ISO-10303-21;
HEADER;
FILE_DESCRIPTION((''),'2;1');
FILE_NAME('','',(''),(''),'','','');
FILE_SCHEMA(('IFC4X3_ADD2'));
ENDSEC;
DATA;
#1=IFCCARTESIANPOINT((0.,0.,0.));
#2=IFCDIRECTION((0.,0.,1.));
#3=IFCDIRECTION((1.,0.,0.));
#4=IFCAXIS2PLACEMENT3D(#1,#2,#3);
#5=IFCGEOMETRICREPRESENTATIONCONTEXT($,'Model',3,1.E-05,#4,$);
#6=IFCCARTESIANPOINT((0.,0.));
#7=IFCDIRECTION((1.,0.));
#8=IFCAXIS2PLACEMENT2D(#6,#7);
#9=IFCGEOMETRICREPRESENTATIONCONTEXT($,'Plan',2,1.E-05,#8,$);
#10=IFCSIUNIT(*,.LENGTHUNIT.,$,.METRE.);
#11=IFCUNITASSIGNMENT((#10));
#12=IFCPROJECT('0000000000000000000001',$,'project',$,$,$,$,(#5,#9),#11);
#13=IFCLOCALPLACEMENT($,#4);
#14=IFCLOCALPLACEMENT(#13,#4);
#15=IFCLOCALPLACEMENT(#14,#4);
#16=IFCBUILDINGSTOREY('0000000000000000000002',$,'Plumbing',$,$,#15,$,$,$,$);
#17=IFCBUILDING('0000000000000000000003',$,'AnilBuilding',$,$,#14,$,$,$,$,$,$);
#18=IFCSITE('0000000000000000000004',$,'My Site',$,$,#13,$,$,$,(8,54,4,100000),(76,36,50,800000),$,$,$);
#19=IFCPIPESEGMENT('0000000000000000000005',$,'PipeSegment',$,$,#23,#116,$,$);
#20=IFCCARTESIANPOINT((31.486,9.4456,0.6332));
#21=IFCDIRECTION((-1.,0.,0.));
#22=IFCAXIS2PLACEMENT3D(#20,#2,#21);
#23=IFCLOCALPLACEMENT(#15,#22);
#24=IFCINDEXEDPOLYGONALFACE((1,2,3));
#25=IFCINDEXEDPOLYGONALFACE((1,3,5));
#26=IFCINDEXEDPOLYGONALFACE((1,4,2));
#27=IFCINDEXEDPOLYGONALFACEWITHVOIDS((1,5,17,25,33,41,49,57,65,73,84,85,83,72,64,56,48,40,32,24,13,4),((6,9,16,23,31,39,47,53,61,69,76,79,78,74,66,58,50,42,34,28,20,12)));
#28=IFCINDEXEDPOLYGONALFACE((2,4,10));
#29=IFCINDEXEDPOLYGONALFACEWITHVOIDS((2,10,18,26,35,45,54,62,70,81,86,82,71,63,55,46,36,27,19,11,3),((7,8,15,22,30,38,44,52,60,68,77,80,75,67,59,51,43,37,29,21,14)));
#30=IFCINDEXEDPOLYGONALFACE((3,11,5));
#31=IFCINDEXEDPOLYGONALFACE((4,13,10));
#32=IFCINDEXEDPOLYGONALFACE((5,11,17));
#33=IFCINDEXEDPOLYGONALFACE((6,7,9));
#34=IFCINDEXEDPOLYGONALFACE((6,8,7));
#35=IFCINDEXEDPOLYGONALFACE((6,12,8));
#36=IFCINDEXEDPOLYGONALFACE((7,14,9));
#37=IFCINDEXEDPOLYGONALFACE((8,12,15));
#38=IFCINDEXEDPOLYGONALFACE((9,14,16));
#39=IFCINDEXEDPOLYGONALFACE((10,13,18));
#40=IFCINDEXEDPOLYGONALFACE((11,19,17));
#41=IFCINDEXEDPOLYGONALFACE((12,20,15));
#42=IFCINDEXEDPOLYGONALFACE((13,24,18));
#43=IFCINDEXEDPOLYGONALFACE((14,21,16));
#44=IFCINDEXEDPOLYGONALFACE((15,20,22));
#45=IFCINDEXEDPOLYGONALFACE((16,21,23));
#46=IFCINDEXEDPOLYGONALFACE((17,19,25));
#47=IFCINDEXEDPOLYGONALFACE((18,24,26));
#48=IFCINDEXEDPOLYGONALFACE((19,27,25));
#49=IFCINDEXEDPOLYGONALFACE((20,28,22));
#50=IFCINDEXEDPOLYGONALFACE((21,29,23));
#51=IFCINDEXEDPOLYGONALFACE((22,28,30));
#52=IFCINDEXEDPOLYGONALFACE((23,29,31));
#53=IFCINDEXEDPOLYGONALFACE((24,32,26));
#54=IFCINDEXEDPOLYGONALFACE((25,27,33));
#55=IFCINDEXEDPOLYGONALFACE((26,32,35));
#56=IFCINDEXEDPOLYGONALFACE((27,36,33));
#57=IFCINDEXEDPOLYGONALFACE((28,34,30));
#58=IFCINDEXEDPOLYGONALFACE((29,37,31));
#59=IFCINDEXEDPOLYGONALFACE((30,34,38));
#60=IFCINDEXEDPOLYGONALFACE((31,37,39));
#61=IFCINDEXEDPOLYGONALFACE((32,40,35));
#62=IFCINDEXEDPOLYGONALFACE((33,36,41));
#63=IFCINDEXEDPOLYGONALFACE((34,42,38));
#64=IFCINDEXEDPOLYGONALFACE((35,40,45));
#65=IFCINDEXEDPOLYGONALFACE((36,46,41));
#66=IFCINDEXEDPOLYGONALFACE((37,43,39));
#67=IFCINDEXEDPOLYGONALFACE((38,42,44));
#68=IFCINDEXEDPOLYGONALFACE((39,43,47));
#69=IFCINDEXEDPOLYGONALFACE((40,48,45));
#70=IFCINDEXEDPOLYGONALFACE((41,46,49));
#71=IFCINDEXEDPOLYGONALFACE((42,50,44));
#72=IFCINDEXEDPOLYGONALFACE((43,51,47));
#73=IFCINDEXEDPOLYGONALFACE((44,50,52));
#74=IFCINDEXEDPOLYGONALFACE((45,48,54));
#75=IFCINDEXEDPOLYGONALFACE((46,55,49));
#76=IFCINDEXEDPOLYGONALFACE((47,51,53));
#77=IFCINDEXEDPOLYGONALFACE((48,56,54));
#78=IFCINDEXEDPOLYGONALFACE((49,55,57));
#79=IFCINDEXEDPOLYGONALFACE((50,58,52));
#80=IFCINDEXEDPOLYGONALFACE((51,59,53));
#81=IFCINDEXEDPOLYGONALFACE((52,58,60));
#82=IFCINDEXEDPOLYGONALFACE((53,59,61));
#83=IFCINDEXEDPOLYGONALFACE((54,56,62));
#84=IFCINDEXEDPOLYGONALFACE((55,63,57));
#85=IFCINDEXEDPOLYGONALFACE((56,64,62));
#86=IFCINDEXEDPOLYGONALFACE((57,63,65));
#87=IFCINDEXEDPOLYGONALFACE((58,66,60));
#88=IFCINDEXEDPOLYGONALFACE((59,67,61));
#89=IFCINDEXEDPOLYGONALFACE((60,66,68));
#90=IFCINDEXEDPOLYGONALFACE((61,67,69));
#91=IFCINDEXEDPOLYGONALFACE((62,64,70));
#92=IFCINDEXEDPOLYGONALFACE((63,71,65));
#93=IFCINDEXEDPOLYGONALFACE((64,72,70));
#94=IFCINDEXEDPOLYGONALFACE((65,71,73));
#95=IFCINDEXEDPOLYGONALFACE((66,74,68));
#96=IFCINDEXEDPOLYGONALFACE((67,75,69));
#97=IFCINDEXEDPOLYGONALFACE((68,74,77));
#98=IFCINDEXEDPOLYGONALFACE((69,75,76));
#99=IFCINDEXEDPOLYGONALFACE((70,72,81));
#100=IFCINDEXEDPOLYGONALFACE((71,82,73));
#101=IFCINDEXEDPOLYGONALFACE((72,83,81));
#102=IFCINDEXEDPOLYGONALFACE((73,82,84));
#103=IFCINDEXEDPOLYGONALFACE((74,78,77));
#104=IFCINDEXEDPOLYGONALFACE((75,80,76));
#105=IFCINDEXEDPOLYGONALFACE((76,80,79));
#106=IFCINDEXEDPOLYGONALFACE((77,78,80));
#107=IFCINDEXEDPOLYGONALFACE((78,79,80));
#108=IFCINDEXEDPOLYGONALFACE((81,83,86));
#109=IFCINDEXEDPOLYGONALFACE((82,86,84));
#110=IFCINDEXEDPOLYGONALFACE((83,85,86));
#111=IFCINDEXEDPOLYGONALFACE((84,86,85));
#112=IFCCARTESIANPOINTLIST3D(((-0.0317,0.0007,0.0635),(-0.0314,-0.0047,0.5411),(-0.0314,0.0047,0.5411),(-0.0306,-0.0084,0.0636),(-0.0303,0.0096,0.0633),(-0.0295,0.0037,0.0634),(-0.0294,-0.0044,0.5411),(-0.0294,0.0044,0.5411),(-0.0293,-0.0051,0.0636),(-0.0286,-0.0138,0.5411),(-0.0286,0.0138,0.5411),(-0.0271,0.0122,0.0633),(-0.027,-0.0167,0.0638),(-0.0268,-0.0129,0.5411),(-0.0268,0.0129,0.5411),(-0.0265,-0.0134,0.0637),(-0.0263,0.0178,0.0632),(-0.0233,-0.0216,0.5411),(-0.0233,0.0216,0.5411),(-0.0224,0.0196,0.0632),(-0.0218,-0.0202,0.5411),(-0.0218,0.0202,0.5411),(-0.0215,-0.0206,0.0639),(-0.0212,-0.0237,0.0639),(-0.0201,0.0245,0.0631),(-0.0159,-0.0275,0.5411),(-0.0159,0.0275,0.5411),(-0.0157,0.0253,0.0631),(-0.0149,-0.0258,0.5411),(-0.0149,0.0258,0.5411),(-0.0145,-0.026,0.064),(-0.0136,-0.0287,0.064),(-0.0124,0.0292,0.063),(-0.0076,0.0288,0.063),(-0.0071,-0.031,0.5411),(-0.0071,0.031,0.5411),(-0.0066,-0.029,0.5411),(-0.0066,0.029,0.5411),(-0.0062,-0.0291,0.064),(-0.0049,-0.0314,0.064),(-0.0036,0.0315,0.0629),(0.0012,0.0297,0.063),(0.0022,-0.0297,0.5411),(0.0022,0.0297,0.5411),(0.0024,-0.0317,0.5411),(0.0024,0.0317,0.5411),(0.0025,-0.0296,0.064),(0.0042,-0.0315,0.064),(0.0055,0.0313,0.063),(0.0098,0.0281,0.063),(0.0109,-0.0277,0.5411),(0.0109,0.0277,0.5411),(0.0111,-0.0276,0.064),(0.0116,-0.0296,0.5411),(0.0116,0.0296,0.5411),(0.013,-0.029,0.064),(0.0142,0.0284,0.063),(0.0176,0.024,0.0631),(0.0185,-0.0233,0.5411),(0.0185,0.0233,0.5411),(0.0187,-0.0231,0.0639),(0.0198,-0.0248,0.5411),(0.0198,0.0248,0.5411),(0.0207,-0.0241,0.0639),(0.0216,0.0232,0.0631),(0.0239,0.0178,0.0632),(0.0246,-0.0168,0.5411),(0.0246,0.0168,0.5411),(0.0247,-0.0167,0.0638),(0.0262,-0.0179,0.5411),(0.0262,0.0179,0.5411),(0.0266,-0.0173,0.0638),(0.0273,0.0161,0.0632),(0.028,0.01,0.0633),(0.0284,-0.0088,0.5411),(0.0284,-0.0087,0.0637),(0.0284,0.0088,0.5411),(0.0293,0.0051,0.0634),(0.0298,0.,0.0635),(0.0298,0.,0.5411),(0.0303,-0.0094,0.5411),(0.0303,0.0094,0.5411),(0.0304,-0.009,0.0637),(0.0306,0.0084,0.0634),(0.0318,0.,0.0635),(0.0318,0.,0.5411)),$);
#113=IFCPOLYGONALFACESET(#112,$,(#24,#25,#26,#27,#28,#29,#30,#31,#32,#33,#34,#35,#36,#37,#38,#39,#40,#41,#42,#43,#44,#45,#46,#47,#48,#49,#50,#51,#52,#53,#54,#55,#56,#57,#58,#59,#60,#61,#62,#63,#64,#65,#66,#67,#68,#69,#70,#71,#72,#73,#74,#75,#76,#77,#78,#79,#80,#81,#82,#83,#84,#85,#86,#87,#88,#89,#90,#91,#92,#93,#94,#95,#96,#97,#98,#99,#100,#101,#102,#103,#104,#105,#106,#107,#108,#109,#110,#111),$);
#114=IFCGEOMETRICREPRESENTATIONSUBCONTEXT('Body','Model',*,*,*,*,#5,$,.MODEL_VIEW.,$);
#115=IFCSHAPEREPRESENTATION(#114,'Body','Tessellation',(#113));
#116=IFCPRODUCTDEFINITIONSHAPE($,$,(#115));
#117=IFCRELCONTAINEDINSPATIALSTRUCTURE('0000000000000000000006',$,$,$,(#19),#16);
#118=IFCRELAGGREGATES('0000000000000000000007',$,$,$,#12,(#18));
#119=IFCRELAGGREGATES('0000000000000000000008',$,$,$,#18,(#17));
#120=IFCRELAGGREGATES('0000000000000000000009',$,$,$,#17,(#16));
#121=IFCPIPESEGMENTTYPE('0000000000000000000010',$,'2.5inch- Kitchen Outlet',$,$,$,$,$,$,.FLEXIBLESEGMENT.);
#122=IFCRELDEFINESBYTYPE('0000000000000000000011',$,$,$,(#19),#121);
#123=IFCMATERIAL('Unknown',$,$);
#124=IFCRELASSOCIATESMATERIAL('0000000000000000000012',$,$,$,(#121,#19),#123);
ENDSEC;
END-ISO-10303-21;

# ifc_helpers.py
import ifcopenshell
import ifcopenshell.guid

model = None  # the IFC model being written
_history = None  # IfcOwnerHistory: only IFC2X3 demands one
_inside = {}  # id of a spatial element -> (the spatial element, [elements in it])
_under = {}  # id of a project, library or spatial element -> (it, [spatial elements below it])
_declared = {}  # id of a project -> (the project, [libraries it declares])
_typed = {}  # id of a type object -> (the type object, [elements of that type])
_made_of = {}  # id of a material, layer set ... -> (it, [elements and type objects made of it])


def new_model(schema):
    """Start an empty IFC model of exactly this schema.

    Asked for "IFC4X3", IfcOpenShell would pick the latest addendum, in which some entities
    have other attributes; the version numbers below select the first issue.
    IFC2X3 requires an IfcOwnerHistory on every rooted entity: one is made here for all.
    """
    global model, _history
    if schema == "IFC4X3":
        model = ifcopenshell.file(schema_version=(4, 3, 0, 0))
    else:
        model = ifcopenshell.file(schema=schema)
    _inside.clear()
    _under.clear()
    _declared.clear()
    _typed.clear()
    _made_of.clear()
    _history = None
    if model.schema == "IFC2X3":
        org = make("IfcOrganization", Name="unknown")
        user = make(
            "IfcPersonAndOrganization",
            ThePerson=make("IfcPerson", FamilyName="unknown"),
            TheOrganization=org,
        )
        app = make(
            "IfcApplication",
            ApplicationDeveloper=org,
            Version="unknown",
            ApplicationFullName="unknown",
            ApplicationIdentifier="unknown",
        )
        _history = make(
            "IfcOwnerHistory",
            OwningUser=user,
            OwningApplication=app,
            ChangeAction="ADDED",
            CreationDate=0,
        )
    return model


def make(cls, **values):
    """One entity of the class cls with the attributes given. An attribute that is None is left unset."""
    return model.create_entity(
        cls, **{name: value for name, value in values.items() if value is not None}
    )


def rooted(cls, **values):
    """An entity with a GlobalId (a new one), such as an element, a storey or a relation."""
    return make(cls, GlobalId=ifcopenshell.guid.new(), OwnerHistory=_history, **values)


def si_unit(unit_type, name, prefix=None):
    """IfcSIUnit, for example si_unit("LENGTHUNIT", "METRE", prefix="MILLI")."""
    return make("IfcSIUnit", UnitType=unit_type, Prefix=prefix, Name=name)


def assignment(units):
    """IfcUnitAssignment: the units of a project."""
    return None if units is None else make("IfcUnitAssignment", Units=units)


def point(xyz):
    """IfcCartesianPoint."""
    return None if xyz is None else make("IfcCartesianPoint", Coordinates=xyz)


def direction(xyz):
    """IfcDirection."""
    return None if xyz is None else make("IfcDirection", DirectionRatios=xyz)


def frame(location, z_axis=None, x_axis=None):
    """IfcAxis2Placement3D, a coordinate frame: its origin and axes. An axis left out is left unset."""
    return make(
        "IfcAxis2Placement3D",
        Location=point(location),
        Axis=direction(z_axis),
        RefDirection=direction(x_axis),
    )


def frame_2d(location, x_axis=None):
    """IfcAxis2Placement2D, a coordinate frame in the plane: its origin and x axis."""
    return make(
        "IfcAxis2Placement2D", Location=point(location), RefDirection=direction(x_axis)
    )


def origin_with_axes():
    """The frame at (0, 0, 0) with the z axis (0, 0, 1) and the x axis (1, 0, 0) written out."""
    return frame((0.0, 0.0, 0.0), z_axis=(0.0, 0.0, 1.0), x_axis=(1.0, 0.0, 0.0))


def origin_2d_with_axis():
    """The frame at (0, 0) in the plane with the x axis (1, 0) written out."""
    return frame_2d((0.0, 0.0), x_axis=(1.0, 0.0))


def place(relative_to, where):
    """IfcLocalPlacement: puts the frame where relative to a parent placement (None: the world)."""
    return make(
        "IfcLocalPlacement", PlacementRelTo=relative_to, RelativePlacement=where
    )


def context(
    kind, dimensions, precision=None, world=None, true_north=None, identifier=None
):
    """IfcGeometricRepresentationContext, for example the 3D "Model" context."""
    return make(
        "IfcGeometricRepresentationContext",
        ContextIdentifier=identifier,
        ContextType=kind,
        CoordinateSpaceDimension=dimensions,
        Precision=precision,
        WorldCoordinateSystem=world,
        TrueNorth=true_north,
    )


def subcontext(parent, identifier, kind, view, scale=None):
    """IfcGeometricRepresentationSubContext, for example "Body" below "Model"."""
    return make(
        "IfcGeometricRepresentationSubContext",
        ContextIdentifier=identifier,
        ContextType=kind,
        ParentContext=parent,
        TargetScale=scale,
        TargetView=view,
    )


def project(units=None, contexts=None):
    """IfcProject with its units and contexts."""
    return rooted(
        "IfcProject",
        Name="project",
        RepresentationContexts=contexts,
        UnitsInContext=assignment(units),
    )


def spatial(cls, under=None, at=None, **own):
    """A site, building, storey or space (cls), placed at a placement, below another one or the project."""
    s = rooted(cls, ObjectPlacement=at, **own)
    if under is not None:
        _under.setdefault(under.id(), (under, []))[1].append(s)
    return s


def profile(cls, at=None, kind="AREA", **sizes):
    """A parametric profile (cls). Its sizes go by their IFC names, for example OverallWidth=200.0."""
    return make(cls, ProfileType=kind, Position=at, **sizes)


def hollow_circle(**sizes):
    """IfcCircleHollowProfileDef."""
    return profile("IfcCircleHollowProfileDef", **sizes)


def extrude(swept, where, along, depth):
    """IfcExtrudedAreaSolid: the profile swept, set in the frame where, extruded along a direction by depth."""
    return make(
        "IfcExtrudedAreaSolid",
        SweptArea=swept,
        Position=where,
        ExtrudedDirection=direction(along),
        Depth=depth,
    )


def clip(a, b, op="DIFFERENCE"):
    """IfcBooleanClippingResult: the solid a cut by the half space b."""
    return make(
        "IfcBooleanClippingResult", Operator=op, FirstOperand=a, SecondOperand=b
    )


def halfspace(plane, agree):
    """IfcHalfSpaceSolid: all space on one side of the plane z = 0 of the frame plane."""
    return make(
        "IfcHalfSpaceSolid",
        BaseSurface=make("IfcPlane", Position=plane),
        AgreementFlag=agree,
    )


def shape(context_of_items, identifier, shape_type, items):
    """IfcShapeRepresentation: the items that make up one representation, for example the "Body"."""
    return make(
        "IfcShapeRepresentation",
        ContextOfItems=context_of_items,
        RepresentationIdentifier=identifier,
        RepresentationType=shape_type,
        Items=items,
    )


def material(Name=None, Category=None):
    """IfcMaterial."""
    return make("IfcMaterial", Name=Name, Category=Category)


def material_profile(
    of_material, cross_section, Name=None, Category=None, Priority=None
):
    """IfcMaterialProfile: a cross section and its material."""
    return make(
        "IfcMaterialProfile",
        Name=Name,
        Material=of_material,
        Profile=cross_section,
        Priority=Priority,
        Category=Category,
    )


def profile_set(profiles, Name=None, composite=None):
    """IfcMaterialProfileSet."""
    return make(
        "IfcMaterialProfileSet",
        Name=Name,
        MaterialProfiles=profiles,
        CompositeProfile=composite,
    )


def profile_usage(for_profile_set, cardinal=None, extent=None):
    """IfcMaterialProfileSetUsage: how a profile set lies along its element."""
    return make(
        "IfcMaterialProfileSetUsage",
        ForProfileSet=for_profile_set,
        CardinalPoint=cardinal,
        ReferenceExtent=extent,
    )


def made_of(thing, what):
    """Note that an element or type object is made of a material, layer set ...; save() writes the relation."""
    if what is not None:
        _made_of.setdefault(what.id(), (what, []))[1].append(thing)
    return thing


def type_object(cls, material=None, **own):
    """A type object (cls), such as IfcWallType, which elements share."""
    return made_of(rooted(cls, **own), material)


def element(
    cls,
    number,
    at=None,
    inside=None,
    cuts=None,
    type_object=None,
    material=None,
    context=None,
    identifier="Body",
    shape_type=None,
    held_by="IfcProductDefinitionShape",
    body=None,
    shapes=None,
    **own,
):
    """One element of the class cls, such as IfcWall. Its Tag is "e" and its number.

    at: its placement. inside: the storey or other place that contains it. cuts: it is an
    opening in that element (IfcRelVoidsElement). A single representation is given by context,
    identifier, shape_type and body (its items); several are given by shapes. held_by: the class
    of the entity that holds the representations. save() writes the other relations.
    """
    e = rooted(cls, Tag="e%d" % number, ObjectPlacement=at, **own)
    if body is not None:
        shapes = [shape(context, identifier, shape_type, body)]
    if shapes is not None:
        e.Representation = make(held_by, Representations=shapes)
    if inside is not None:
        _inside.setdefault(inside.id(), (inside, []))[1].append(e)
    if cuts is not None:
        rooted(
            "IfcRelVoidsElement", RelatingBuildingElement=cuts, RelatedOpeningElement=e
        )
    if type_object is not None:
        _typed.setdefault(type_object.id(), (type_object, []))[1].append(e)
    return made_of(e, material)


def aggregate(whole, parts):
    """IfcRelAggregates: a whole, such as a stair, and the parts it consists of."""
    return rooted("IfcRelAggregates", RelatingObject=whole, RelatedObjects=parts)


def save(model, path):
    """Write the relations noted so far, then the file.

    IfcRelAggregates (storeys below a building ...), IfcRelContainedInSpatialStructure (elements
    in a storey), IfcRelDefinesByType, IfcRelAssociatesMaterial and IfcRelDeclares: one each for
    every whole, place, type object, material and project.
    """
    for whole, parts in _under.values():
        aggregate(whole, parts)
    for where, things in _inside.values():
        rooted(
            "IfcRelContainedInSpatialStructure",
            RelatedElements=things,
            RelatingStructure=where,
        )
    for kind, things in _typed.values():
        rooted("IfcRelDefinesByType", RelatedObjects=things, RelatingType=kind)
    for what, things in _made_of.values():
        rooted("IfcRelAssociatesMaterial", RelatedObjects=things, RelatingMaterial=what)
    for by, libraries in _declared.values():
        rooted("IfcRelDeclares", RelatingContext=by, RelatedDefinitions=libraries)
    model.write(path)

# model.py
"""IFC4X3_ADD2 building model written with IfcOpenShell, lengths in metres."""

from ifc_helpers import new_model, si_unit, frame, origin_with_axes, origin_2d_with_axis, place, context, subcontext, project, spatial, hollow_circle, extrude, clip, halfspace, material, material_profile, profile_set, profile_usage, type_object, element, save


model = new_model("IFC4X3_ADD2")

# Units and contexts
model_context = context("Model", 3, precision=1e-05, world=origin_with_axes())
plan_context = context("Plan", 2, precision=1e-05, world=origin_2d_with_axis())
body_context = subcontext(model_context, "Body", "Model", "MODEL_VIEW")
ifc_project = project(units=[si_unit("LENGTHUNIT", "METRE")], contexts=[model_context, plan_context])

# Site, building, storey
site_placement = place(None, origin_with_axes())
site = spatial("IfcSite", under=ifc_project, at=site_placement, Name="My Site", RefLatitude=(8, 54, 4, 100000), RefLongitude=(76, 36, 50, 800000))
building_placement = place(site_placement, origin_with_axes())
building = spatial("IfcBuilding", under=site, at=building_placement, Name="AnilBuilding")
storey_placement = place(building_placement, origin_with_axes())
storey = spatial("IfcBuildingStorey", under=building, at=storey_placement, Name="Plumbing")

# Pipe segment
ifc_material_1 = material(Name="Unknown")
ifc_material_profile_1 = material_profile(ifc_material_1, hollow_circle(Radius=0.0318, WallThickness=0.002))
ifc_profile_set_1 = profile_set([ifc_material_profile_1], Name="kitchenwater")
pipe_segment_type_1 = type_object("IfcPipeSegmentType", Name="2.5inch- Kitchen Outlet", PredefinedType="FLEXIBLESEGMENT", material=ifc_profile_set_1)
ifc_profile_usage_1 = profile_usage(ifc_profile_set_1)
pipe_segment_1_placement = place(storey_placement, frame((31.486, 9.4456, 0.6332), z_axis=(0.0, 0.0, 1.0), x_axis=(-1.0, 0.0, 0.0)))
element("IfcPipeSegment", 1, at=pipe_segment_1_placement, inside=storey, type_object=pipe_segment_type_1, material=ifc_profile_usage_1, Name="PipeSegment", context=body_context, shape_type="Clipping", body=[
    clip(extrude(hollow_circle(Radius=0.0318, WallThickness=0.002), origin_with_axes(), (0.0, 0.0, 1.0), 0.5411), halfspace(frame((0.0, -0.0323, 0.0641), z_axis=(0.0, -0.017452, -0.999848), x_axis=(-1.0, -0.000019, 0.0)), False)),
])

save(model, "model.ifc")
